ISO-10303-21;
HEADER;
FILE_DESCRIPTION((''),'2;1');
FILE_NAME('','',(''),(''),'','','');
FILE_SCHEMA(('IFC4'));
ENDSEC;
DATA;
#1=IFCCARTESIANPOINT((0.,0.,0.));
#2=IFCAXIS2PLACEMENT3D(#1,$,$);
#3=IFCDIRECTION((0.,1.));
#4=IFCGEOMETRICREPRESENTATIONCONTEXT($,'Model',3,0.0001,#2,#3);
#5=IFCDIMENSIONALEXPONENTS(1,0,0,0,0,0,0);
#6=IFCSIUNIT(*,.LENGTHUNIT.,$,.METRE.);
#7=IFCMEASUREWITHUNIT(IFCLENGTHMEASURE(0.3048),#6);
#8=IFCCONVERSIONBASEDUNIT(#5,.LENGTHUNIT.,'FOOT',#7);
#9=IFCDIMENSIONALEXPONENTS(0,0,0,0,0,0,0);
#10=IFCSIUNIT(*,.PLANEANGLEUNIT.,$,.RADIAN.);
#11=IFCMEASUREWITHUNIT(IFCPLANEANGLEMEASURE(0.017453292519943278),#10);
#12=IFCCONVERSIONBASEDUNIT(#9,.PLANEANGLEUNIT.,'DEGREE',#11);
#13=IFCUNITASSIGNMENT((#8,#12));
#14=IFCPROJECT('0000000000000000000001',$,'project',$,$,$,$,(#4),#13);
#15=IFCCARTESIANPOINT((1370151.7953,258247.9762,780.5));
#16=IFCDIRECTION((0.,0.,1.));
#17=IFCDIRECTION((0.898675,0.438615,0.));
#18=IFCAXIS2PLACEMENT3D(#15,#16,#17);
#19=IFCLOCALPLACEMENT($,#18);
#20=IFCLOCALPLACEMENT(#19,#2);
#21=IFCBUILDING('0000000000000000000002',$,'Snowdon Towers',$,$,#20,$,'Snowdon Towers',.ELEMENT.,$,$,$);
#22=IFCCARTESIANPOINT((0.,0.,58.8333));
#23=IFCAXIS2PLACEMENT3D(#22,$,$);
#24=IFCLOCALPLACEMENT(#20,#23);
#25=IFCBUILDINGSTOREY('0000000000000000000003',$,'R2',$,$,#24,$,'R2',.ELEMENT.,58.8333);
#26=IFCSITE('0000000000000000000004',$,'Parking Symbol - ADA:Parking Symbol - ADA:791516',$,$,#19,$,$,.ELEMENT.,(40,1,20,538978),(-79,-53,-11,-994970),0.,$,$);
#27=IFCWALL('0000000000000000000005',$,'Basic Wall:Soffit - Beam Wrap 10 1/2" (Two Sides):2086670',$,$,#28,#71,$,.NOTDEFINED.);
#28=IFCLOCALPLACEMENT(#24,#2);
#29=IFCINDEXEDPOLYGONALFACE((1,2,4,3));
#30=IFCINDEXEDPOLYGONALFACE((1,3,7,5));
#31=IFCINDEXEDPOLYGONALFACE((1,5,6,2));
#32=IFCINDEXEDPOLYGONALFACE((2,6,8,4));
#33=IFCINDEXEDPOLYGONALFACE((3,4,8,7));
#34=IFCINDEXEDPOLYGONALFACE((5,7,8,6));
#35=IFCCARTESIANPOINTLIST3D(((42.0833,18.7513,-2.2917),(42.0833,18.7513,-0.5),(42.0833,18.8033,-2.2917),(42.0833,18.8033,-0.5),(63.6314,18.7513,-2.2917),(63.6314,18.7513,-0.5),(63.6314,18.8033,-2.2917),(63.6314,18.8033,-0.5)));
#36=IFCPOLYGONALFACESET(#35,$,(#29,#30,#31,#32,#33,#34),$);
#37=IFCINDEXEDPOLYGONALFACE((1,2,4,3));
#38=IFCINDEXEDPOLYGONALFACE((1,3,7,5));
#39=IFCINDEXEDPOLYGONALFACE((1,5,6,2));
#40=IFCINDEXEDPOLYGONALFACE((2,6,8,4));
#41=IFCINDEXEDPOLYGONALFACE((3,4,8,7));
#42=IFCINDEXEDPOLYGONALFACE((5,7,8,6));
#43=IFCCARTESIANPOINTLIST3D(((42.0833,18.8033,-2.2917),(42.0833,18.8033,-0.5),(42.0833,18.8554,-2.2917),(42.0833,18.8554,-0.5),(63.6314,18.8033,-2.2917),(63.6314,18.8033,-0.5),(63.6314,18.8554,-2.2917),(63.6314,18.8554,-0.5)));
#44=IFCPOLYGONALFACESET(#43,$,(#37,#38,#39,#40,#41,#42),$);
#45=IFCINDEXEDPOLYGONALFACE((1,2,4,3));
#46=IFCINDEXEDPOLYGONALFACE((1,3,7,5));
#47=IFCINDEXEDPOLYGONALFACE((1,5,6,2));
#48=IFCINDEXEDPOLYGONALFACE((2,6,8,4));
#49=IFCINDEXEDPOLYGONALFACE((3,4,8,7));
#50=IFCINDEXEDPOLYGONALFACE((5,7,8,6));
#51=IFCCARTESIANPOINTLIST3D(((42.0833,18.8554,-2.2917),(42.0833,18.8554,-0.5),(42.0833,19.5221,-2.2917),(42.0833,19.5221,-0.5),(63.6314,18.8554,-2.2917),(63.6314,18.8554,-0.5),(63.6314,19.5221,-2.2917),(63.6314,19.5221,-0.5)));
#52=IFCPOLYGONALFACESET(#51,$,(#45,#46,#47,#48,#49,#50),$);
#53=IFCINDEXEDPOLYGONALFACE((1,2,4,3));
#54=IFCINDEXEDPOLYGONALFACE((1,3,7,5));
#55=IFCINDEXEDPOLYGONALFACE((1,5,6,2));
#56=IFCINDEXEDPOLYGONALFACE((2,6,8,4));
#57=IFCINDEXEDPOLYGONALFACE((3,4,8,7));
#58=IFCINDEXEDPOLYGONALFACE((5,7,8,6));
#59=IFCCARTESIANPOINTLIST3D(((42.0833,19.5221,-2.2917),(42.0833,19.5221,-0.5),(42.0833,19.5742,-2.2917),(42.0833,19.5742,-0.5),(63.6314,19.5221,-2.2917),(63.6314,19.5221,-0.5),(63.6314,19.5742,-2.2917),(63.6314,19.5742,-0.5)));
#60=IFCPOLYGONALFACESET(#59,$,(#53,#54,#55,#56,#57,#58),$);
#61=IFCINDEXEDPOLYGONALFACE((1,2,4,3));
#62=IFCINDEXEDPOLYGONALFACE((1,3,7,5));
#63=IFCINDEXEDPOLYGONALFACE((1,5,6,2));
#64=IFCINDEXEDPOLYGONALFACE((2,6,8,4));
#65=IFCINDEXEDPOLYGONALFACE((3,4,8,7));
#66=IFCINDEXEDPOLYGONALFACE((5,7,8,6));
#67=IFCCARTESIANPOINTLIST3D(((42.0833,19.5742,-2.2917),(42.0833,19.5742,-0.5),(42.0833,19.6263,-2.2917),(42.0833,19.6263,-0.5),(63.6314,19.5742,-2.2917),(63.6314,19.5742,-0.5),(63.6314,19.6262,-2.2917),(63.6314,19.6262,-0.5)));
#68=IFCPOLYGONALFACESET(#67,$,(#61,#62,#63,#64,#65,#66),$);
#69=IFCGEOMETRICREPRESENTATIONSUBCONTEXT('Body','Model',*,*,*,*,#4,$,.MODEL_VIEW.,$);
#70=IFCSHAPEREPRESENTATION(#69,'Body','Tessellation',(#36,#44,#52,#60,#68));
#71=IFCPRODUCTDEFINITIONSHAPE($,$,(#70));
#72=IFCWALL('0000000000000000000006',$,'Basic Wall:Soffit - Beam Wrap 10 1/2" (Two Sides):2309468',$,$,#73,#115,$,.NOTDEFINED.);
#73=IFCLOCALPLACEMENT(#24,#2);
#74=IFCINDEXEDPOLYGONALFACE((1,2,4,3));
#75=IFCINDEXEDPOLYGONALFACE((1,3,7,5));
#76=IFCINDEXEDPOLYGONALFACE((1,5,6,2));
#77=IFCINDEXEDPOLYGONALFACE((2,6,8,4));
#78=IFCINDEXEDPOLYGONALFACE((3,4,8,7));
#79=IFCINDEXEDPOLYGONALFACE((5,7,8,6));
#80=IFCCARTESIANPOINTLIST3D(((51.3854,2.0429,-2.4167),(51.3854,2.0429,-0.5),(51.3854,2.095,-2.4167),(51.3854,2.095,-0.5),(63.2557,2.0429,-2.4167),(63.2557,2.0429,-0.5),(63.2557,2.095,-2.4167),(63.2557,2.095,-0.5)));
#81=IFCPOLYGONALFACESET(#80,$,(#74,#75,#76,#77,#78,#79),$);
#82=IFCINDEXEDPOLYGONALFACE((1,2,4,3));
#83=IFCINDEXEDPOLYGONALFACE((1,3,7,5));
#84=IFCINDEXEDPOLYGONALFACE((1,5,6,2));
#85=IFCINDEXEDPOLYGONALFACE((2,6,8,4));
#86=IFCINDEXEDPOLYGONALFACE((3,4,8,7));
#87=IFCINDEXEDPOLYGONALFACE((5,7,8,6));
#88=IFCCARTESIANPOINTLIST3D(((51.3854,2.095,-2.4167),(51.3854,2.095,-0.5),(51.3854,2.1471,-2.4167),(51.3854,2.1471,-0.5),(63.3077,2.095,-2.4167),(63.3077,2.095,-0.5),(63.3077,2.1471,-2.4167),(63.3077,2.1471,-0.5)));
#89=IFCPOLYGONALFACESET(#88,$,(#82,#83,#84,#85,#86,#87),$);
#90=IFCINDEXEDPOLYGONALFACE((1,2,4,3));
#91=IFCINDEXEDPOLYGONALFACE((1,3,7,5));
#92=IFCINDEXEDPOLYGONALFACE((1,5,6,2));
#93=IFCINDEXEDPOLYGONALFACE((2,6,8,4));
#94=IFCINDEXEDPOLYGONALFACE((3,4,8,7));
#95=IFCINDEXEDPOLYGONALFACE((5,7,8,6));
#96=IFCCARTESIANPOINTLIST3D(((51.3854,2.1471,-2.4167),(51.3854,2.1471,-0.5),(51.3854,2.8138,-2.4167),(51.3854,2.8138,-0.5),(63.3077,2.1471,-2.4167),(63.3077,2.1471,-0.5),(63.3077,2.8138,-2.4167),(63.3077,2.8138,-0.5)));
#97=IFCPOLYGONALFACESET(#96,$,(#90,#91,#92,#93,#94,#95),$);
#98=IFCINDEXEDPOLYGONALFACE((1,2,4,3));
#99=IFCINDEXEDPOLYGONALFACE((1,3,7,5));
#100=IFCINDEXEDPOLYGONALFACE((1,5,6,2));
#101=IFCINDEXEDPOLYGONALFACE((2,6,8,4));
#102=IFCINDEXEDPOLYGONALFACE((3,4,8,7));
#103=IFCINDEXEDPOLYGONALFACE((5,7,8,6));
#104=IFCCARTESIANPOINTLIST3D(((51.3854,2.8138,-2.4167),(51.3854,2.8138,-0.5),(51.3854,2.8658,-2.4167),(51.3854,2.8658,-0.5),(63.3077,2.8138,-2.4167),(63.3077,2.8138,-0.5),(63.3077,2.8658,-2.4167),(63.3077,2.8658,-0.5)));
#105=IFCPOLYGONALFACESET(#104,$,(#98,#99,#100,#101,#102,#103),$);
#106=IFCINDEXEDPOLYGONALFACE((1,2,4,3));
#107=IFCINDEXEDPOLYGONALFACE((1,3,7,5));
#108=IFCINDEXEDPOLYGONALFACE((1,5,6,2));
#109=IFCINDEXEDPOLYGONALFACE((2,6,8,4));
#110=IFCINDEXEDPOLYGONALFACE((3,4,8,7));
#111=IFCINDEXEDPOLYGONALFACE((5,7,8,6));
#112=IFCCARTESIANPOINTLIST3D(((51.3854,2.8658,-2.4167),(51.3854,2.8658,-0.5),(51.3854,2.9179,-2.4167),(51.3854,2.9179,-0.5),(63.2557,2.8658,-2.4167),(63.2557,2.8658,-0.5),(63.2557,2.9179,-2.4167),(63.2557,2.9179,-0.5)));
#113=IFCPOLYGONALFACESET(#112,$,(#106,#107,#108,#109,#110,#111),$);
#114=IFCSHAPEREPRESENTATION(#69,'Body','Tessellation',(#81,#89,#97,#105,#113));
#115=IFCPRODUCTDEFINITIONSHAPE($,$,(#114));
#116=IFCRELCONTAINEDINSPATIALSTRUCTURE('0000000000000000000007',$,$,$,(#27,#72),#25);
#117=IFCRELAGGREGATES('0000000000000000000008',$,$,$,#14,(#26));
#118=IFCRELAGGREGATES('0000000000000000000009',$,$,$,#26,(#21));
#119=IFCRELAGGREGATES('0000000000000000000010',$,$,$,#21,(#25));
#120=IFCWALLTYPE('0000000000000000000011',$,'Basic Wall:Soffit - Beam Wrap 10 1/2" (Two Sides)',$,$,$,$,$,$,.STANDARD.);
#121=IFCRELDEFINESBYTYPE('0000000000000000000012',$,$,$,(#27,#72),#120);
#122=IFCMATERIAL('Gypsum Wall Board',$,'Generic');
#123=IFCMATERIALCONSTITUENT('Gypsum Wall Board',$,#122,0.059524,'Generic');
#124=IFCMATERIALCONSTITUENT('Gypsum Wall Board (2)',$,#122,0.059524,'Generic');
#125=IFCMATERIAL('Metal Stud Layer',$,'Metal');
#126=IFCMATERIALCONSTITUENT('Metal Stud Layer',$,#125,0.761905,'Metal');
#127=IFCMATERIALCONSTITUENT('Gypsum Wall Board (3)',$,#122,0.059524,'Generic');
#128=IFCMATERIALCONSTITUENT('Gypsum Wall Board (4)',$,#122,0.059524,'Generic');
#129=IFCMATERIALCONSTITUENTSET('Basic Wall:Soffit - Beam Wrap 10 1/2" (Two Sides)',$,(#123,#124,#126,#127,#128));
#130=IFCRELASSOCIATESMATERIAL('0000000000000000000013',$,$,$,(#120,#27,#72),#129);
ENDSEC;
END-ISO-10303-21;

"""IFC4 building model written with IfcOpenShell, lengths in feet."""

from ifc_helpers import new_model, entity, si_unit, converted_unit, direction, frame, origin, place, context, subcontext, project, spatial, indexed_curve, outline, extrude, material, constituent, constituent_set, type_object, element, save


model = new_model("IFC4")

# Units and contexts
model_context = context("Model", 3, precision=0.0001, world=origin(), true_north=direction((0.0, 1.0)))
body_context = subcontext(model_context, "Body", "Model", "MODEL_VIEW")
ifc_project = project(units=[converted_unit("LENGTHUNIT", "FOOT", entity("IfcLengthMeasure", 0.3048), si_unit("LENGTHUNIT", "METRE"), dimensions=[1, 0, 0, 0, 0, 0, 0]), converted_unit("PLANEANGLEUNIT", "DEGREE", entity("IfcPlaneAngleMeasure", 0.017453292519943278), si_unit("PLANEANGLEUNIT", "RADIAN"), dimensions=[0, 0, 0, 0, 0, 0, 0])], contexts=[model_context])

# Site, building, storey
site_placement = place(None, frame((1370151.7953, 258247.9762, 780.5), z_axis=(0.0, 0.0, 1.0), x_axis=(0.898675, 0.438615, 0.0)))
site = spatial("IfcSite", under=ifc_project, at=site_placement, Name="Parking Symbol - ADA:Parking Symbol - ADA:791516", CompositionType="ELEMENT", RefLatitude=(40, 1, 20, 538978), RefLongitude=(-79, -53, -11, -994970), RefElevation=0.0)
building_placement = place(site_placement, origin())
building = spatial("IfcBuilding", under=site, at=building_placement, Name="Snowdon Towers", LongName="Snowdon Towers", CompositionType="ELEMENT")
storey_placement = place(building_placement, frame((0.0, 0.0, 58.8333)))
storey = spatial("IfcBuildingStorey", under=building, at=storey_placement, Name="R2", LongName="R2", CompositionType="ELEMENT", Elevation=58.8333)

# Shared definitions
ifc_material_1 = material(Name="Gypsum Wall Board", Category="Generic")
ifc_material_2 = material(Name="Metal Stud Layer", Category="Metal")

# Walls
ifc_constituent_1 = constituent(ifc_material_1, Name="Gypsum Wall Board", Category="Generic", fraction=0.059524)
ifc_constituent_2 = constituent(ifc_material_1, Name="Gypsum Wall Board (2)", Category="Generic", fraction=0.059524)
ifc_constituent_3 = constituent(ifc_material_2, Name="Metal Stud Layer", Category="Metal", fraction=0.761905)
ifc_constituent_4 = constituent(ifc_material_1, Name="Gypsum Wall Board (3)", Category="Generic", fraction=0.059524)
ifc_constituent_5 = constituent(ifc_material_1, Name="Gypsum Wall Board (4)", Category="Generic", fraction=0.059524)
ifc_constituent_set_1 = constituent_set(constituents=[ifc_constituent_1, ifc_constituent_2, ifc_constituent_3, ifc_constituent_4, ifc_constituent_5], Name="Basic Wall:Soffit - Beam Wrap 10 1/2\" (Two Sides)")
wall_type_1 = type_object("IfcWallType", Name="Basic Wall:Soffit - Beam Wrap 10 1/2\" (Two Sides)", PredefinedType="STANDARD", material=ifc_constituent_set_1)
wall_1_placement = place(storey_placement, frame((42.0833, 19.1887, -2.2917)))
element("IfcWall", 1, at=wall_1_placement, inside=storey, type_object=wall_type_1, material=ifc_constituent_set_1, Name="Basic Wall:Soffit - Beam Wrap 10 1/2\" (Two Sides):2086670", PredefinedType="NOTDEFINED", context=body_context, shape_type="SweptSolid", body=[
    extrude(outline(indexed_curve([(-0.026, -10.774), (0.026, -10.774), (0.026, 10.774), (-0.026, 10.774), (-0.026, -10.774)], self_intersect=False)), frame((10.774, -0.4115, 0.0), z_axis=(0.0, 0.0, 1.0), x_axis=(0.0, 1.0, 0.0)), (0.0, 0.0, 1.0), 1.7917),
    extrude(outline(indexed_curve([(-10.774, -0.026), (10.774, -0.026), (10.774, 0.026), (-10.774, 0.026), (-10.774, -0.026)], self_intersect=False)), frame((10.774, -0.3594, 0.0)), (0.0, 0.0, 1.0), 1.7917),
    extrude(outline(indexed_curve([(-10.774, -0.3333), (10.774, -0.3333), (10.774, 0.3333), (-10.774, 0.3333), (-10.774, -0.3333)], self_intersect=False)), frame((10.774, 0.0, 0.0)), (0.0, 0.0, 1.0), 1.7917),
    extrude(outline(indexed_curve([(-10.774, -0.026), (10.774, -0.026), (10.774, 0.026), (-10.774, 0.026), (-10.774, -0.026)], self_intersect=False)), frame((10.774, 0.3594, 0.0)), (0.0, 0.0, 1.0), 1.7917),
    extrude(outline(indexed_curve([(-0.026, -10.774), (0.026, -10.774), (0.026, 10.774), (-0.026, 10.774), (-0.026, -10.774)], self_intersect=False)), frame((10.774, 0.4115, 0.0), z_axis=(0.0, 0.0, 1.0), x_axis=(0.0, -1.0, 0.0)), (0.0, 0.0, 1.0), 1.7917),
])
wall_2_placement = place(storey_placement, frame((51.3854, 2.4804, -2.4167)))
element("IfcWall", 2, at=wall_2_placement, inside=storey, type_object=wall_type_1, material=ifc_constituent_set_1, Name="Basic Wall:Soffit - Beam Wrap 10 1/2\" (Two Sides):2309468", PredefinedType="NOTDEFINED", context=body_context, shape_type="SweptSolid", body=[
    extrude(outline(indexed_curve([(-0.026, -5.9351), (0.026, -5.9351), (0.026, 5.9351), (-0.026, 5.9351), (-0.026, -5.9351)], self_intersect=False)), frame((5.9351, -0.4115, 0.0), z_axis=(0.0, 0.0, 1.0), x_axis=(0.0, 1.0, 0.0)), (0.0, 0.0, 1.0), 1.9167),
    extrude(outline(indexed_curve([(-5.9612, -0.026), (5.9612, -0.026), (5.9612, 0.026), (-5.9612, 0.026), (-5.9612, -0.026)], self_intersect=False)), frame((5.9612, -0.3594, 0.0)), (0.0, 0.0, 1.0), 1.9167),
    extrude(outline(indexed_curve([(-5.9612, -0.3333), (5.9612, -0.3333), (5.9612, 0.3333), (-5.9612, 0.3333), (-5.9612, -0.3333)], self_intersect=False)), frame((5.9612, 0.0, 0.0)), (0.0, 0.0, 1.0), 1.9167),
    extrude(outline(indexed_curve([(-5.9612, -0.026), (5.9612, -0.026), (5.9612, 0.026), (-5.9612, 0.026), (-5.9612, -0.026)], self_intersect=False)), frame((5.9612, 0.3594, 0.0)), (0.0, 0.0, 1.0), 1.9167),
    extrude(outline(indexed_curve([(-0.026, -5.9351), (0.026, -5.9351), (0.026, 5.9351), (-0.026, 5.9351), (-0.026, -5.9351)], self_intersect=False)), frame((5.9351, 0.4115, 0.0), z_axis=(0.0, 0.0, 1.0), x_axis=(0.0, -1.0, 0.0)), (0.0, 0.0, 1.0), 1.9167),
])

save(model, "model.ifc")
